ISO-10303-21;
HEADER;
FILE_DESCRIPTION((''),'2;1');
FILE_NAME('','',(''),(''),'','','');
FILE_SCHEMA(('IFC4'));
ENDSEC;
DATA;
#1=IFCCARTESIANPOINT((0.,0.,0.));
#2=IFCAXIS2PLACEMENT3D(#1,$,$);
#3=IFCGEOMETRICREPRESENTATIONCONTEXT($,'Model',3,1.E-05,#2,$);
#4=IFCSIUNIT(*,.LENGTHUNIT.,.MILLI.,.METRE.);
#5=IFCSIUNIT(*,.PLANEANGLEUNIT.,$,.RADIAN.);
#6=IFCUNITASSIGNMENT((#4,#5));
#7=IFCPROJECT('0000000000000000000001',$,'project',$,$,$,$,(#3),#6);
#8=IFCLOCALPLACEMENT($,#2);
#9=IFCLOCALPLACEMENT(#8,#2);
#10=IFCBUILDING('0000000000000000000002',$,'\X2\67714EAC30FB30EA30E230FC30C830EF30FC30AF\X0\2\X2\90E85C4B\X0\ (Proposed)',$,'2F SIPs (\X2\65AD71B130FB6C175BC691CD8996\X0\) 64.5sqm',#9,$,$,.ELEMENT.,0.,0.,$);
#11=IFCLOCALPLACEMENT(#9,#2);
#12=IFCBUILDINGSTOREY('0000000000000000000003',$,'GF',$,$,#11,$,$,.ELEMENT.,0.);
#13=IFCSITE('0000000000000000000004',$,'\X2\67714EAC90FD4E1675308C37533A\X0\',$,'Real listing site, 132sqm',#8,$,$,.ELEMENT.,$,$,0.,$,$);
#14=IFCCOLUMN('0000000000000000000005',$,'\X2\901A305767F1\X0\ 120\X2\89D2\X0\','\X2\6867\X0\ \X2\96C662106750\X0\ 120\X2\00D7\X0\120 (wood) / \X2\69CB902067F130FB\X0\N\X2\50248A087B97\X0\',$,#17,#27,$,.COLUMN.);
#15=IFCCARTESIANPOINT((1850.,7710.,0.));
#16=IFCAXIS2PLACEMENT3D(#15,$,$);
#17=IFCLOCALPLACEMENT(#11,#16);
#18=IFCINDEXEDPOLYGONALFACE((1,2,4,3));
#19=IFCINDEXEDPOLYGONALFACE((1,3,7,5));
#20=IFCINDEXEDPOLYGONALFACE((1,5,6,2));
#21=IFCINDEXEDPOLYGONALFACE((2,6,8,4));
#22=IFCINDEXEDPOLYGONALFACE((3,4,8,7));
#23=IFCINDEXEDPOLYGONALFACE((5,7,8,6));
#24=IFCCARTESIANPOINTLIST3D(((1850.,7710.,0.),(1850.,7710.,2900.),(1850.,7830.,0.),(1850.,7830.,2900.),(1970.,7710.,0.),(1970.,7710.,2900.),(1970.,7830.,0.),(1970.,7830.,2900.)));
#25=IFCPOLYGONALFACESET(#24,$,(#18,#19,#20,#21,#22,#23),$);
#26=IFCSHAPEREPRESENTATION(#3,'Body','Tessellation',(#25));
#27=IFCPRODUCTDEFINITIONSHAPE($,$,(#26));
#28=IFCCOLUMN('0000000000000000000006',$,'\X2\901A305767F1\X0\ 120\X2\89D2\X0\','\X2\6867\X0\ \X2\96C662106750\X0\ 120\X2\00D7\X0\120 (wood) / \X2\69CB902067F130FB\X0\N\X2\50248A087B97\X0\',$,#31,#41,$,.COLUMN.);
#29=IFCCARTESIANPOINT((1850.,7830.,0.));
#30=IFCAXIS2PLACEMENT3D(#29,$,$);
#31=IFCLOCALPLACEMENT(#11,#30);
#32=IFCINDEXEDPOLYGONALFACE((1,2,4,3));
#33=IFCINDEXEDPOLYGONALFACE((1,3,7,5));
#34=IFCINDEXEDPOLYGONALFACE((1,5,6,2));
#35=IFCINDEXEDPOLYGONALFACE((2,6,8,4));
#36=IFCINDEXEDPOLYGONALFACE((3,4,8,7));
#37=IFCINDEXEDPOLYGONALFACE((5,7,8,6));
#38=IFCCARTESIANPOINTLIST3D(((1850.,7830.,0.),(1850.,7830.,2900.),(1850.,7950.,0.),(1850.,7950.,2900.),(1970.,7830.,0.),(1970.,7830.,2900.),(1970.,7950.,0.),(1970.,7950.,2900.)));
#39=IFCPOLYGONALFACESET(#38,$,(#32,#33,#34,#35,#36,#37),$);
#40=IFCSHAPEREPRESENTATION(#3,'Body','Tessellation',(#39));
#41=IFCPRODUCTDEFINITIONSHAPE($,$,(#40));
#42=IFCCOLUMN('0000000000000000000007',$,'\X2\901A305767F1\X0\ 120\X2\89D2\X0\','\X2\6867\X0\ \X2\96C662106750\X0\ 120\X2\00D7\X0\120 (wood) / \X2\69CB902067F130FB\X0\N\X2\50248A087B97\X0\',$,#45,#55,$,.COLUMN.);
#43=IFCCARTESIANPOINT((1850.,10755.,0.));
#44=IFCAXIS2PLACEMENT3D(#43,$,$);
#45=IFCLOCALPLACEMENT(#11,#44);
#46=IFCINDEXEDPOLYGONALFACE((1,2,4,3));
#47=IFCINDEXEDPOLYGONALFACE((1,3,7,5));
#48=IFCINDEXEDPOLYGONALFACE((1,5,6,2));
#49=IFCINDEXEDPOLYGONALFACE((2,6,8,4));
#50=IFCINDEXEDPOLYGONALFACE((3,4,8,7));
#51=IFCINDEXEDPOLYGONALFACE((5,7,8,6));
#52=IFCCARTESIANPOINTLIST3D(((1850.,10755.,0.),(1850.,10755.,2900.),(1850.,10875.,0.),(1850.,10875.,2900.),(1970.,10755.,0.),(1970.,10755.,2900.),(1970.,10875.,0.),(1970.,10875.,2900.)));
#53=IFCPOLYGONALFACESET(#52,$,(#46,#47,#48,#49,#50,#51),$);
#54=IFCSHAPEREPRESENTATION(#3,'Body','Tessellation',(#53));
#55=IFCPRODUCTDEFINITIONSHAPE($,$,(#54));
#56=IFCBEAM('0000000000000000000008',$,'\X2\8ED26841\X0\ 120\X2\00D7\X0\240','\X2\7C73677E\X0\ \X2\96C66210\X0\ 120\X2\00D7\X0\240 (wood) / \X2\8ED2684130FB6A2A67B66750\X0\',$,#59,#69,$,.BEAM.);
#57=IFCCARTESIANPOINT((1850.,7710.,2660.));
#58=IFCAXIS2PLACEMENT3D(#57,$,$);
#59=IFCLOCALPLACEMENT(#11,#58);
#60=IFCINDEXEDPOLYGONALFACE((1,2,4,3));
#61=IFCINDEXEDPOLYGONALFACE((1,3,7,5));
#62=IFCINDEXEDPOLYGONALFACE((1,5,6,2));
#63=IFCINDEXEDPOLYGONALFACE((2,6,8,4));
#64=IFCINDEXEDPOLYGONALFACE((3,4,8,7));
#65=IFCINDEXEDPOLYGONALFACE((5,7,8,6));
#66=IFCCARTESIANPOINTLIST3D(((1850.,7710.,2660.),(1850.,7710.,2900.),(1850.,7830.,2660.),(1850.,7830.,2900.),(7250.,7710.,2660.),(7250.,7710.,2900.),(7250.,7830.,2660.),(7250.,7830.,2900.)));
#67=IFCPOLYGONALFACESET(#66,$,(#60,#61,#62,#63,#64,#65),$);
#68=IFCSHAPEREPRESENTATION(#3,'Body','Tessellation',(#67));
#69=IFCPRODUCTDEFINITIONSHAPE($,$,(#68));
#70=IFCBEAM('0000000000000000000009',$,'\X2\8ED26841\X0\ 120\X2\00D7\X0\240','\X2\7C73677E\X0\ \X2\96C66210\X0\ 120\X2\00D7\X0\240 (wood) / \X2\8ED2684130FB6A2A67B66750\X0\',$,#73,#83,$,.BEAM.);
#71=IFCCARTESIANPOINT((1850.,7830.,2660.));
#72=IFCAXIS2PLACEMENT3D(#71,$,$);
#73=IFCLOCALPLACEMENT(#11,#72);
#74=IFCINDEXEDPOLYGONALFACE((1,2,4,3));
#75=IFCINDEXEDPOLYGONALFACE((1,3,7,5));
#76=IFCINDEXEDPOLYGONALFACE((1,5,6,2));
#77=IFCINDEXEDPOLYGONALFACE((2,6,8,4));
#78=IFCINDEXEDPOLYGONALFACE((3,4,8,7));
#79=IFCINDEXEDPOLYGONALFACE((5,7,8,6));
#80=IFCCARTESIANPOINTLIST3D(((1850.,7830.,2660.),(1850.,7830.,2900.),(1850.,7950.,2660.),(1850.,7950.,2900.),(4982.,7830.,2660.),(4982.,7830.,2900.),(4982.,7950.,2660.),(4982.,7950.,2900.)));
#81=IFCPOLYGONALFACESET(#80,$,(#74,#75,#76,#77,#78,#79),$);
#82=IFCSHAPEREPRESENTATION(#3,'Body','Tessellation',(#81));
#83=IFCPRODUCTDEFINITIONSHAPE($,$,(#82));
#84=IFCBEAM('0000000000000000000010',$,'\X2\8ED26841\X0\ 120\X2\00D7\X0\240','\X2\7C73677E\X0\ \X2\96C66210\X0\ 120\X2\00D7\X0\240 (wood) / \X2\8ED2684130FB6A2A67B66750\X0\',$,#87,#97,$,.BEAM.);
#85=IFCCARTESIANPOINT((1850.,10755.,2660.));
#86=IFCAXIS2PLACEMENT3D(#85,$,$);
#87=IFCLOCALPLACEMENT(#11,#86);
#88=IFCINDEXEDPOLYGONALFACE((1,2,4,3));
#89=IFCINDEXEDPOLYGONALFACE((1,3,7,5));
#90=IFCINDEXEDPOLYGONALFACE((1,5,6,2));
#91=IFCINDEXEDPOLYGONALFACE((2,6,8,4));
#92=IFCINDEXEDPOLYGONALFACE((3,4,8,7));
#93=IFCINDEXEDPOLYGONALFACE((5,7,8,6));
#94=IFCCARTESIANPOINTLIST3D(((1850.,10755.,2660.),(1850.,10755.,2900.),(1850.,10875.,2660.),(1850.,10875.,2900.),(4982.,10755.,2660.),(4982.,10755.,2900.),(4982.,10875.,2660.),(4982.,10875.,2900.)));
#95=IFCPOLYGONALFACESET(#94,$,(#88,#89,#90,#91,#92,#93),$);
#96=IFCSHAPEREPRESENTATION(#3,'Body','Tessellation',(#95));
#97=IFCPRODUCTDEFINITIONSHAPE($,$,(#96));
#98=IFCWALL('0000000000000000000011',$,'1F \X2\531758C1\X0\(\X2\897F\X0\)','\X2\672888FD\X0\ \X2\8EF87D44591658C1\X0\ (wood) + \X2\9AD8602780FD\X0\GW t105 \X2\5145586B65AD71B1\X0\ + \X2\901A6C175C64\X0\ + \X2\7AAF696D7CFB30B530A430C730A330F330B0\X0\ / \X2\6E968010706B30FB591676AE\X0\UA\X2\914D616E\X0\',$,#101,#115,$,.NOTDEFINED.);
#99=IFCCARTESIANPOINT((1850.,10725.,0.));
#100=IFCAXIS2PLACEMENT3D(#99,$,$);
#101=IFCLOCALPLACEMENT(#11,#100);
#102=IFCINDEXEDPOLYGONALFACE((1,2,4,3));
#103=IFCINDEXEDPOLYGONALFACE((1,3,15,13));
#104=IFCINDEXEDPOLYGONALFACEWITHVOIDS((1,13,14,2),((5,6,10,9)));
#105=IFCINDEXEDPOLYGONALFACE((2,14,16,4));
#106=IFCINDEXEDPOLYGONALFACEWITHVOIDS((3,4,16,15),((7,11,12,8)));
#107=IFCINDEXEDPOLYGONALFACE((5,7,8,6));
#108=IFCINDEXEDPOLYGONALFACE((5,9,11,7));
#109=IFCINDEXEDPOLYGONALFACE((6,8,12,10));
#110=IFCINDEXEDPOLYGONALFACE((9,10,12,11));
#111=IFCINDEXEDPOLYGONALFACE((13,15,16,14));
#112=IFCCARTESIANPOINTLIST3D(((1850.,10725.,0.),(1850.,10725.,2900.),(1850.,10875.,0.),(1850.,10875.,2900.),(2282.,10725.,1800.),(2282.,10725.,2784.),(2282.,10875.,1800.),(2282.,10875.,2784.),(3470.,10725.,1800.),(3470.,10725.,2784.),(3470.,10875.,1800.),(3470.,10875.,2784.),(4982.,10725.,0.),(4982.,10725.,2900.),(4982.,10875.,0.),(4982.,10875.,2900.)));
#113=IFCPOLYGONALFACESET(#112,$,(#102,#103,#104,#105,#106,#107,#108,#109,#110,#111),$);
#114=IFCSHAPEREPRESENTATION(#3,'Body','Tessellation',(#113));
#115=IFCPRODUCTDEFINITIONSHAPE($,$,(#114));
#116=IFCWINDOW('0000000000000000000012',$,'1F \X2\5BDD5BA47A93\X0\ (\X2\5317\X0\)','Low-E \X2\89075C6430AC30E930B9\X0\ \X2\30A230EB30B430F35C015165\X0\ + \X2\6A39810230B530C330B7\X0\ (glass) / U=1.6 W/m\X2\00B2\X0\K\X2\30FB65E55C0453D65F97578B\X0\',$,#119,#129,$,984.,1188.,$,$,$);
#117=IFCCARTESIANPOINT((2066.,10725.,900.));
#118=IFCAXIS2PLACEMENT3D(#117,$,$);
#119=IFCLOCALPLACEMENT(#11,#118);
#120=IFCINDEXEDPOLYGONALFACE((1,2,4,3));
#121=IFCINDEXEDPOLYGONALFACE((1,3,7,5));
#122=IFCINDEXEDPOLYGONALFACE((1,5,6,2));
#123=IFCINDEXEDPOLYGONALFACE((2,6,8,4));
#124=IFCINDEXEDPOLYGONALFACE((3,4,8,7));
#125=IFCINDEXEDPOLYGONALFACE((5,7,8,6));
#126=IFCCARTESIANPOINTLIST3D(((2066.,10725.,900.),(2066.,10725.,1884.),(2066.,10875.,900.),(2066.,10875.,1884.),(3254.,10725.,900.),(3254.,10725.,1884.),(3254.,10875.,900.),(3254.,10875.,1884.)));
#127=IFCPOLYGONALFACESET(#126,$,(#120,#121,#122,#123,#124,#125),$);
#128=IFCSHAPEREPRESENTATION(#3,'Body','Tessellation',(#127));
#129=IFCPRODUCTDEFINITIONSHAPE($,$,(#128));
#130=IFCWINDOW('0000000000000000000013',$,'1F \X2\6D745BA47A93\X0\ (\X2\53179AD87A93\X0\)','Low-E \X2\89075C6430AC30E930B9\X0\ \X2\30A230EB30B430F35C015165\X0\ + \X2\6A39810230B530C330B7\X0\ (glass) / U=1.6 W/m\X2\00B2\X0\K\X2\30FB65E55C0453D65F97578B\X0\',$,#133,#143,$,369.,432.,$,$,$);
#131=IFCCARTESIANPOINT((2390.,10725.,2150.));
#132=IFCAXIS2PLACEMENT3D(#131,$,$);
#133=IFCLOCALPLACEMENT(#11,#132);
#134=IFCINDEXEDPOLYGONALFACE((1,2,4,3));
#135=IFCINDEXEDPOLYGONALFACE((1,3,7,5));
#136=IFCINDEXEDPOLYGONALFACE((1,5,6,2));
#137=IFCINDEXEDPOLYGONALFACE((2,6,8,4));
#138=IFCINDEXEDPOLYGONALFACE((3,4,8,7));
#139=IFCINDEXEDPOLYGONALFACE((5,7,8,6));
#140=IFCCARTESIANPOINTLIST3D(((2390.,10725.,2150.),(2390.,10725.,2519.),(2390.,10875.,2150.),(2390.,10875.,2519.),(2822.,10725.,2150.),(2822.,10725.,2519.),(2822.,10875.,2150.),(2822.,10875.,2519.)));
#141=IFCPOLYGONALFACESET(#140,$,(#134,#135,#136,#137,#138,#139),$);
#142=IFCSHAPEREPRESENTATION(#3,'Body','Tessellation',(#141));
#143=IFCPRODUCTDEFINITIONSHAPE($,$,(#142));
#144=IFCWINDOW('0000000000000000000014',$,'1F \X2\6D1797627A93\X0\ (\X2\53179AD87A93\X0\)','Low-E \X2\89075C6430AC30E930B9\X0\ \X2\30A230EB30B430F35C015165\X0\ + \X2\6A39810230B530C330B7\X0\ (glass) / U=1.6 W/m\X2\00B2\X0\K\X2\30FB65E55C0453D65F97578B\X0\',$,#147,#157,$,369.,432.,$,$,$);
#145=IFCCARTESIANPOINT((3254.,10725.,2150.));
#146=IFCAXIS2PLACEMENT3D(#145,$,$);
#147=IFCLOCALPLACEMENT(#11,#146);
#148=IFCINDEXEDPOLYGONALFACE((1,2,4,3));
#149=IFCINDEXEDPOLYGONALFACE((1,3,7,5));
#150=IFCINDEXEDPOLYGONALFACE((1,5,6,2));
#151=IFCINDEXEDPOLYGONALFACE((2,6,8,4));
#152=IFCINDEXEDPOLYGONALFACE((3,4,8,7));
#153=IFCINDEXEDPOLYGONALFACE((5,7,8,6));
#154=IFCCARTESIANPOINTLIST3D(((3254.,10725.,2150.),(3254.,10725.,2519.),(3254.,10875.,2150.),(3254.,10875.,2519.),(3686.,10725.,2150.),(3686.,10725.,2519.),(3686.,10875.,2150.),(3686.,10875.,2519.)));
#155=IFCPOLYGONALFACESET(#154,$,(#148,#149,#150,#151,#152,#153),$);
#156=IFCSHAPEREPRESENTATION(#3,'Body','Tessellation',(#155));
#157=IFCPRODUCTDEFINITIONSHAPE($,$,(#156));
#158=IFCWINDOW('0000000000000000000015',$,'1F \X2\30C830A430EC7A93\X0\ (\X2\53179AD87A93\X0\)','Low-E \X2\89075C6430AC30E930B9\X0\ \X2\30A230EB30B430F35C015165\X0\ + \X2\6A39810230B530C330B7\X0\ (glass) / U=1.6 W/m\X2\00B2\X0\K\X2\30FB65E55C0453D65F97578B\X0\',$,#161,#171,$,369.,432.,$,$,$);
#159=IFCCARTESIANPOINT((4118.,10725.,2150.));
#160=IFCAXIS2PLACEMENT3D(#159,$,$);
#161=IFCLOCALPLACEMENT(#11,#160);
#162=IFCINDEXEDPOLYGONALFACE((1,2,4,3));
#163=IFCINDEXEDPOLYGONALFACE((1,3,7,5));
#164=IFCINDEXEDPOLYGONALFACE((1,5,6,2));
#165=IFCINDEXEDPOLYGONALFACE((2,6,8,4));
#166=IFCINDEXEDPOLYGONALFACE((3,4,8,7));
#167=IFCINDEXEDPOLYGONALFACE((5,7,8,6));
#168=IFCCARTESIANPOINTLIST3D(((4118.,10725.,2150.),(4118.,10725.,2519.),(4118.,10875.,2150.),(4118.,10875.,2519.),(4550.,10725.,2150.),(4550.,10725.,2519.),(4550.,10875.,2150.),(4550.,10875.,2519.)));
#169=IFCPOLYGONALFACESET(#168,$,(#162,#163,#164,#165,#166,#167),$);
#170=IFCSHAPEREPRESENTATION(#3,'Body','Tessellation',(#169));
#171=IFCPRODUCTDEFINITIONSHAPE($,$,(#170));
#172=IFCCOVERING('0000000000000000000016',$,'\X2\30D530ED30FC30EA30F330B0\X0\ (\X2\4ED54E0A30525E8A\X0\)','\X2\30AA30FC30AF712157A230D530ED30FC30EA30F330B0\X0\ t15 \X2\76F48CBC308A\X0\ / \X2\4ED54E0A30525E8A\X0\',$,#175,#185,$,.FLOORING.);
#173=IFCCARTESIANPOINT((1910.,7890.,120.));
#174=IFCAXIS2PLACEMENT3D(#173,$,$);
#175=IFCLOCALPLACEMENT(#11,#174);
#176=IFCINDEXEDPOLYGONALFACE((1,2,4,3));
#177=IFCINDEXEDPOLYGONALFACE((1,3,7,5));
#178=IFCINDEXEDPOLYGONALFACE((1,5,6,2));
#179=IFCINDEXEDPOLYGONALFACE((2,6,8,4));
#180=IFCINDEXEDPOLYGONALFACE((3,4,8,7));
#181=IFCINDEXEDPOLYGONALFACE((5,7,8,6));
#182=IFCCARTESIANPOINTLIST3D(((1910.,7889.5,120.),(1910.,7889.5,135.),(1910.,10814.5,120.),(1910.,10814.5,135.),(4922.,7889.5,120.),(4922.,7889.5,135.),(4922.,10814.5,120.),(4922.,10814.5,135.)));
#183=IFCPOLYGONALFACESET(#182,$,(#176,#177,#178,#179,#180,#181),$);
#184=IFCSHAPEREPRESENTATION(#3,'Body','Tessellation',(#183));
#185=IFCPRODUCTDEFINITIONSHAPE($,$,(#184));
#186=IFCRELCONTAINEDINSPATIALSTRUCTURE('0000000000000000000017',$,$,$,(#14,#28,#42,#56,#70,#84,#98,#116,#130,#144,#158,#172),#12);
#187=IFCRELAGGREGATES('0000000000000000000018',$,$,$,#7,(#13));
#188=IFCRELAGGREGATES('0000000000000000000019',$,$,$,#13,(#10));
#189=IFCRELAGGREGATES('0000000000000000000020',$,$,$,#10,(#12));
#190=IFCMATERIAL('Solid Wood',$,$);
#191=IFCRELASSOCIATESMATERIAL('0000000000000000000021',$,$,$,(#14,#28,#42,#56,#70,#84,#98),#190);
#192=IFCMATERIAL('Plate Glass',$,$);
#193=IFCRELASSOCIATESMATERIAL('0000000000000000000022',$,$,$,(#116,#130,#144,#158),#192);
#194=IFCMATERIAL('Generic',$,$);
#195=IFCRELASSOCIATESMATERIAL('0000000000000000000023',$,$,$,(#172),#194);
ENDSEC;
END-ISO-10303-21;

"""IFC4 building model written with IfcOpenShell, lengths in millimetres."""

from ifc_helpers import new_model, si_unit, frame, frame_2d, origin, place, context, project, spatial, rectangle, extrude, material, element, fill, save


model = new_model("IFC4")

# Units and contexts
model_context = context("Model", 3, precision=1e-05, world=origin())
ifc_project = project(units=[si_unit("LENGTHUNIT", "METRE", prefix="MILLI"), si_unit("PLANEANGLEUNIT", "RADIAN")], contexts=[model_context])

# Site, building, storey
site_placement = place(None, origin())
site = spatial("IfcSite", under=ifc_project, at=site_placement, Name="東京都世田谷区", ObjectType="Real listing site, 132sqm", CompositionType="ELEMENT", RefElevation=0.0)
building_placement = place(site_placement, origin())
building = spatial("IfcBuilding", under=site, at=building_placement, Name="東京・リモートワーク2部屋 (Proposed)", ObjectType="2F SIPs (断熱・気密重視) 64.5sqm", CompositionType="ELEMENT", ElevationOfRefHeight=0.0, ElevationOfTerrain=0.0)
storey_placement = place(building_placement, origin())
storey = spatial("IfcBuildingStorey", under=building, at=storey_placement, Name="GF", CompositionType="ELEMENT", Elevation=0.0)

# Columns
ifc_material_1 = material(Name="Solid Wood")
column_1_placement = place(storey_placement, frame((1850.0, 7710.0, 0.0)))
element("IfcColumn", 1, at=column_1_placement, inside=storey, material=ifc_material_1, Name="通し柱 120角", Description="桧 集成材 120×120 (wood) / 構造柱・N値計算", PredefinedType="COLUMN", context=model_context, shape_type="SweptSolid", body=[
    extrude(rectangle(XDim=120.0, YDim=120.0, at=frame_2d((60.0, 60.0))), frame((1850.0, 7710.0, 0.0)), (0.0, 0.0, 1.0), 2900.0),
])
column_2_placement = place(storey_placement, frame((1850.0, 7830.0, 0.0)))
element("IfcColumn", 2, at=column_2_placement, inside=storey, material=ifc_material_1, Name="通し柱 120角", Description="桧 集成材 120×120 (wood) / 構造柱・N値計算", PredefinedType="COLUMN", context=model_context, shape_type="SweptSolid", body=[
    extrude(rectangle(XDim=120.0, YDim=120.0, at=frame_2d((60.0, 60.0))), frame((1850.0, 7830.0, 0.0)), (0.0, 0.0, 1.0), 2900.0),
])
column_3_placement = place(storey_placement, frame((1850.0, 10755.0, 0.0)))
element("IfcColumn", 3, at=column_3_placement, inside=storey, material=ifc_material_1, Name="通し柱 120角", Description="桧 集成材 120×120 (wood) / 構造柱・N値計算", PredefinedType="COLUMN", context=model_context, shape_type="SweptSolid", body=[
    extrude(rectangle(XDim=120.0, YDim=120.0, at=frame_2d((60.0, 60.0))), frame((1850.0, 10755.0, 0.0)), (0.0, 0.0, 1.0), 2900.0),
])

# Beams
beam_1_placement = place(storey_placement, frame((1850.0, 7710.0, 2660.0)))
element("IfcBeam", 4, at=beam_1_placement, inside=storey, material=ifc_material_1, Name="軒桁 120×240", Description="米松 集成 120×240 (wood) / 軒桁・横架材", PredefinedType="BEAM", context=model_context, shape_type="SweptSolid", body=[
    extrude(rectangle(XDim=5400.0, YDim=120.0, at=frame_2d((2700.0, 60.0))), frame((1850.0, 7710.0, 2660.0)), (0.0, 0.0, 1.0), 240.0),
])
beam_2_placement = place(storey_placement, frame((1850.0, 7830.0, 2660.0)))
element("IfcBeam", 5, at=beam_2_placement, inside=storey, material=ifc_material_1, Name="軒桁 120×240", Description="米松 集成 120×240 (wood) / 軒桁・横架材", PredefinedType="BEAM", context=model_context, shape_type="SweptSolid", body=[
    extrude(rectangle(XDim=3132.0, YDim=120.0, at=frame_2d((1566.0, 60.0))), frame((1850.0, 7830.0, 2660.0)), (0.0, 0.0, 1.0), 240.0),
])
beam_3_placement = place(storey_placement, frame((1850.0, 10755.0, 2660.0)))
element("IfcBeam", 6, at=beam_3_placement, inside=storey, material=ifc_material_1, Name="軒桁 120×240", Description="米松 集成 120×240 (wood) / 軒桁・横架材", PredefinedType="BEAM", context=model_context, shape_type="SweptSolid", body=[
    extrude(rectangle(XDim=3132.0, YDim=120.0, at=frame_2d((1566.0, 60.0))), frame((1850.0, 10755.0, 2660.0)), (0.0, 0.0, 1.0), 240.0),
])

# Wall, openings, windows
wall_1_placement = place(storey_placement, frame((1850.0, 10725.0, 0.0)))
wall_1 = element("IfcWall", 7, at=wall_1_placement, inside=storey, material=ifc_material_1, Name="1F 北壁(西)", Description="木製 軸組外壁 (wood) + 高性能GW t105 充填断熱 + 通気層 + 窯業系サイディング / 準耐火・外皮UA配慮", PredefinedType="NOTDEFINED", context=model_context, shape_type="SweptSolid", body=[
    extrude(rectangle(XDim=3132.0, YDim=150.0, at=frame_2d((1566.0, 75.0))), frame((1850.0, 10725.0, 0.0)), (0.0, 0.0, 1.0), 2900.0),
])
opening_1_placement = place(storey_placement, frame((2066.0, 10725.0, 900.0)))
opening_1 = element("IfcOpeningElement", 8, at=opening_1_placement, cuts=wall_1, PredefinedType="NOTDEFINED", context=model_context, shape_type="SweptSolid", body=[
    extrude(rectangle(XDim=1188.0, YDim=150.0, at=frame_2d((594.0, 75.0))), frame((2066.0, 10725.0, 900.0)), (0.0, 0.0, 1.0), 984.0),
])
opening_2_placement = place(storey_placement, frame((2390.0, 10725.0, 2150.0)))
opening_2 = element("IfcOpeningElement", 9, at=opening_2_placement, cuts=wall_1, PredefinedType="NOTDEFINED", context=model_context, shape_type="SweptSolid", body=[
    extrude(rectangle(XDim=432.0, YDim=150.0, at=frame_2d((216.0, 75.0))), frame((2390.0, 10725.0, 2150.0)), (0.0, 0.0, 1.0), 369.0),
])
opening_3_placement = place(storey_placement, frame((3254.0, 10725.0, 2150.0)))
opening_3 = element("IfcOpeningElement", 10, at=opening_3_placement, cuts=wall_1, PredefinedType="NOTDEFINED", context=model_context, shape_type="SweptSolid", body=[
    extrude(rectangle(XDim=432.0, YDim=150.0, at=frame_2d((216.0, 75.0))), frame((3254.0, 10725.0, 2150.0)), (0.0, 0.0, 1.0), 369.0),
])
opening_4_placement = place(storey_placement, frame((4118.0, 10725.0, 2150.0)))
opening_4 = element("IfcOpeningElement", 11, at=opening_4_placement, cuts=wall_1, PredefinedType="NOTDEFINED", context=model_context, shape_type="SweptSolid", body=[
    extrude(rectangle(XDim=432.0, YDim=150.0, at=frame_2d((216.0, 75.0))), frame((4118.0, 10725.0, 2150.0)), (0.0, 0.0, 1.0), 369.0),
])
ifc_material_2 = material(Name="Plate Glass")
window_1_placement = place(storey_placement, frame((2066.0, 10725.0, 900.0)))
window_1 = element("IfcWindow", 12, at=window_1_placement, inside=storey, material=ifc_material_2, Name="1F 寝室窓 (北)", Description="Low-E 複層ガラス アルゴン封入 + 樹脂サッシ (glass) / U=1.6 W/m²K・日射取得型", OverallHeight=984.0, OverallWidth=1188.0, context=model_context, shape_type="SweptSolid", body=[
    extrude(rectangle(XDim=1188.0, YDim=150.0, at=frame_2d((594.0, 75.0))), frame((2066.0, 10725.0, 900.0)), (0.0, 0.0, 1.0), 984.0),
])
fill(opening_1, window_1)
window_2_placement = place(storey_placement, frame((2390.0, 10725.0, 2150.0)))
window_2 = element("IfcWindow", 13, at=window_2_placement, inside=storey, material=ifc_material_2, Name="1F 浴室窓 (北高窓)", Description="Low-E 複層ガラス アルゴン封入 + 樹脂サッシ (glass) / U=1.6 W/m²K・日射取得型", OverallHeight=369.0, OverallWidth=432.0, context=model_context, shape_type="SweptSolid", body=[
    extrude(rectangle(XDim=432.0, YDim=150.0, at=frame_2d((216.0, 75.0))), frame((2390.0, 10725.0, 2150.0)), (0.0, 0.0, 1.0), 369.0),
])
fill(opening_2, window_2)
window_3_placement = place(storey_placement, frame((3254.0, 10725.0, 2150.0)))
window_3 = element("IfcWindow", 14, at=window_3_placement, inside=storey, material=ifc_material_2, Name="1F 洗面窓 (北高窓)", Description="Low-E 複層ガラス アルゴン封入 + 樹脂サッシ (glass) / U=1.6 W/m²K・日射取得型", OverallHeight=369.0, OverallWidth=432.0, context=model_context, shape_type="SweptSolid", body=[
    extrude(rectangle(XDim=432.0, YDim=150.0, at=frame_2d((216.0, 75.0))), frame((3254.0, 10725.0, 2150.0)), (0.0, 0.0, 1.0), 369.0),
])
fill(opening_3, window_3)
window_4_placement = place(storey_placement, frame((4118.0, 10725.0, 2150.0)))
window_4 = element("IfcWindow", 15, at=window_4_placement, inside=storey, material=ifc_material_2, Name="1F トイレ窓 (北高窓)", Description="Low-E 複層ガラス アルゴン封入 + 樹脂サッシ (glass) / U=1.6 W/m²K・日射取得型", OverallHeight=369.0, OverallWidth=432.0, context=model_context, shape_type="SweptSolid", body=[
    extrude(rectangle(XDim=432.0, YDim=150.0, at=frame_2d((216.0, 75.0))), frame((4118.0, 10725.0, 2150.0)), (0.0, 0.0, 1.0), 369.0),
])
fill(opening_4, window_4)

# Covering
ifc_material_3 = material(Name="Generic")
covering_placement = place(storey_placement, frame((1910.0, 7890.0, 120.0)))
element("IfcCovering", 16, at=covering_placement, inside=storey, material=ifc_material_3, Name="フローリング (仕上げ床)", Description="オーク無垢フローリング t15 直貼り / 仕上げ床", PredefinedType="FLOORING", context=model_context, shape_type="SweptSolid", body=[
    extrude(rectangle(XDim=3012.0, YDim=2925.0, at=frame_2d((1506.0, 1462.0))), frame((1910.0, 7890.0, 120.0)), (0.0, 0.0, 1.0), 15.0),
])

save(model, "model.ifc")
